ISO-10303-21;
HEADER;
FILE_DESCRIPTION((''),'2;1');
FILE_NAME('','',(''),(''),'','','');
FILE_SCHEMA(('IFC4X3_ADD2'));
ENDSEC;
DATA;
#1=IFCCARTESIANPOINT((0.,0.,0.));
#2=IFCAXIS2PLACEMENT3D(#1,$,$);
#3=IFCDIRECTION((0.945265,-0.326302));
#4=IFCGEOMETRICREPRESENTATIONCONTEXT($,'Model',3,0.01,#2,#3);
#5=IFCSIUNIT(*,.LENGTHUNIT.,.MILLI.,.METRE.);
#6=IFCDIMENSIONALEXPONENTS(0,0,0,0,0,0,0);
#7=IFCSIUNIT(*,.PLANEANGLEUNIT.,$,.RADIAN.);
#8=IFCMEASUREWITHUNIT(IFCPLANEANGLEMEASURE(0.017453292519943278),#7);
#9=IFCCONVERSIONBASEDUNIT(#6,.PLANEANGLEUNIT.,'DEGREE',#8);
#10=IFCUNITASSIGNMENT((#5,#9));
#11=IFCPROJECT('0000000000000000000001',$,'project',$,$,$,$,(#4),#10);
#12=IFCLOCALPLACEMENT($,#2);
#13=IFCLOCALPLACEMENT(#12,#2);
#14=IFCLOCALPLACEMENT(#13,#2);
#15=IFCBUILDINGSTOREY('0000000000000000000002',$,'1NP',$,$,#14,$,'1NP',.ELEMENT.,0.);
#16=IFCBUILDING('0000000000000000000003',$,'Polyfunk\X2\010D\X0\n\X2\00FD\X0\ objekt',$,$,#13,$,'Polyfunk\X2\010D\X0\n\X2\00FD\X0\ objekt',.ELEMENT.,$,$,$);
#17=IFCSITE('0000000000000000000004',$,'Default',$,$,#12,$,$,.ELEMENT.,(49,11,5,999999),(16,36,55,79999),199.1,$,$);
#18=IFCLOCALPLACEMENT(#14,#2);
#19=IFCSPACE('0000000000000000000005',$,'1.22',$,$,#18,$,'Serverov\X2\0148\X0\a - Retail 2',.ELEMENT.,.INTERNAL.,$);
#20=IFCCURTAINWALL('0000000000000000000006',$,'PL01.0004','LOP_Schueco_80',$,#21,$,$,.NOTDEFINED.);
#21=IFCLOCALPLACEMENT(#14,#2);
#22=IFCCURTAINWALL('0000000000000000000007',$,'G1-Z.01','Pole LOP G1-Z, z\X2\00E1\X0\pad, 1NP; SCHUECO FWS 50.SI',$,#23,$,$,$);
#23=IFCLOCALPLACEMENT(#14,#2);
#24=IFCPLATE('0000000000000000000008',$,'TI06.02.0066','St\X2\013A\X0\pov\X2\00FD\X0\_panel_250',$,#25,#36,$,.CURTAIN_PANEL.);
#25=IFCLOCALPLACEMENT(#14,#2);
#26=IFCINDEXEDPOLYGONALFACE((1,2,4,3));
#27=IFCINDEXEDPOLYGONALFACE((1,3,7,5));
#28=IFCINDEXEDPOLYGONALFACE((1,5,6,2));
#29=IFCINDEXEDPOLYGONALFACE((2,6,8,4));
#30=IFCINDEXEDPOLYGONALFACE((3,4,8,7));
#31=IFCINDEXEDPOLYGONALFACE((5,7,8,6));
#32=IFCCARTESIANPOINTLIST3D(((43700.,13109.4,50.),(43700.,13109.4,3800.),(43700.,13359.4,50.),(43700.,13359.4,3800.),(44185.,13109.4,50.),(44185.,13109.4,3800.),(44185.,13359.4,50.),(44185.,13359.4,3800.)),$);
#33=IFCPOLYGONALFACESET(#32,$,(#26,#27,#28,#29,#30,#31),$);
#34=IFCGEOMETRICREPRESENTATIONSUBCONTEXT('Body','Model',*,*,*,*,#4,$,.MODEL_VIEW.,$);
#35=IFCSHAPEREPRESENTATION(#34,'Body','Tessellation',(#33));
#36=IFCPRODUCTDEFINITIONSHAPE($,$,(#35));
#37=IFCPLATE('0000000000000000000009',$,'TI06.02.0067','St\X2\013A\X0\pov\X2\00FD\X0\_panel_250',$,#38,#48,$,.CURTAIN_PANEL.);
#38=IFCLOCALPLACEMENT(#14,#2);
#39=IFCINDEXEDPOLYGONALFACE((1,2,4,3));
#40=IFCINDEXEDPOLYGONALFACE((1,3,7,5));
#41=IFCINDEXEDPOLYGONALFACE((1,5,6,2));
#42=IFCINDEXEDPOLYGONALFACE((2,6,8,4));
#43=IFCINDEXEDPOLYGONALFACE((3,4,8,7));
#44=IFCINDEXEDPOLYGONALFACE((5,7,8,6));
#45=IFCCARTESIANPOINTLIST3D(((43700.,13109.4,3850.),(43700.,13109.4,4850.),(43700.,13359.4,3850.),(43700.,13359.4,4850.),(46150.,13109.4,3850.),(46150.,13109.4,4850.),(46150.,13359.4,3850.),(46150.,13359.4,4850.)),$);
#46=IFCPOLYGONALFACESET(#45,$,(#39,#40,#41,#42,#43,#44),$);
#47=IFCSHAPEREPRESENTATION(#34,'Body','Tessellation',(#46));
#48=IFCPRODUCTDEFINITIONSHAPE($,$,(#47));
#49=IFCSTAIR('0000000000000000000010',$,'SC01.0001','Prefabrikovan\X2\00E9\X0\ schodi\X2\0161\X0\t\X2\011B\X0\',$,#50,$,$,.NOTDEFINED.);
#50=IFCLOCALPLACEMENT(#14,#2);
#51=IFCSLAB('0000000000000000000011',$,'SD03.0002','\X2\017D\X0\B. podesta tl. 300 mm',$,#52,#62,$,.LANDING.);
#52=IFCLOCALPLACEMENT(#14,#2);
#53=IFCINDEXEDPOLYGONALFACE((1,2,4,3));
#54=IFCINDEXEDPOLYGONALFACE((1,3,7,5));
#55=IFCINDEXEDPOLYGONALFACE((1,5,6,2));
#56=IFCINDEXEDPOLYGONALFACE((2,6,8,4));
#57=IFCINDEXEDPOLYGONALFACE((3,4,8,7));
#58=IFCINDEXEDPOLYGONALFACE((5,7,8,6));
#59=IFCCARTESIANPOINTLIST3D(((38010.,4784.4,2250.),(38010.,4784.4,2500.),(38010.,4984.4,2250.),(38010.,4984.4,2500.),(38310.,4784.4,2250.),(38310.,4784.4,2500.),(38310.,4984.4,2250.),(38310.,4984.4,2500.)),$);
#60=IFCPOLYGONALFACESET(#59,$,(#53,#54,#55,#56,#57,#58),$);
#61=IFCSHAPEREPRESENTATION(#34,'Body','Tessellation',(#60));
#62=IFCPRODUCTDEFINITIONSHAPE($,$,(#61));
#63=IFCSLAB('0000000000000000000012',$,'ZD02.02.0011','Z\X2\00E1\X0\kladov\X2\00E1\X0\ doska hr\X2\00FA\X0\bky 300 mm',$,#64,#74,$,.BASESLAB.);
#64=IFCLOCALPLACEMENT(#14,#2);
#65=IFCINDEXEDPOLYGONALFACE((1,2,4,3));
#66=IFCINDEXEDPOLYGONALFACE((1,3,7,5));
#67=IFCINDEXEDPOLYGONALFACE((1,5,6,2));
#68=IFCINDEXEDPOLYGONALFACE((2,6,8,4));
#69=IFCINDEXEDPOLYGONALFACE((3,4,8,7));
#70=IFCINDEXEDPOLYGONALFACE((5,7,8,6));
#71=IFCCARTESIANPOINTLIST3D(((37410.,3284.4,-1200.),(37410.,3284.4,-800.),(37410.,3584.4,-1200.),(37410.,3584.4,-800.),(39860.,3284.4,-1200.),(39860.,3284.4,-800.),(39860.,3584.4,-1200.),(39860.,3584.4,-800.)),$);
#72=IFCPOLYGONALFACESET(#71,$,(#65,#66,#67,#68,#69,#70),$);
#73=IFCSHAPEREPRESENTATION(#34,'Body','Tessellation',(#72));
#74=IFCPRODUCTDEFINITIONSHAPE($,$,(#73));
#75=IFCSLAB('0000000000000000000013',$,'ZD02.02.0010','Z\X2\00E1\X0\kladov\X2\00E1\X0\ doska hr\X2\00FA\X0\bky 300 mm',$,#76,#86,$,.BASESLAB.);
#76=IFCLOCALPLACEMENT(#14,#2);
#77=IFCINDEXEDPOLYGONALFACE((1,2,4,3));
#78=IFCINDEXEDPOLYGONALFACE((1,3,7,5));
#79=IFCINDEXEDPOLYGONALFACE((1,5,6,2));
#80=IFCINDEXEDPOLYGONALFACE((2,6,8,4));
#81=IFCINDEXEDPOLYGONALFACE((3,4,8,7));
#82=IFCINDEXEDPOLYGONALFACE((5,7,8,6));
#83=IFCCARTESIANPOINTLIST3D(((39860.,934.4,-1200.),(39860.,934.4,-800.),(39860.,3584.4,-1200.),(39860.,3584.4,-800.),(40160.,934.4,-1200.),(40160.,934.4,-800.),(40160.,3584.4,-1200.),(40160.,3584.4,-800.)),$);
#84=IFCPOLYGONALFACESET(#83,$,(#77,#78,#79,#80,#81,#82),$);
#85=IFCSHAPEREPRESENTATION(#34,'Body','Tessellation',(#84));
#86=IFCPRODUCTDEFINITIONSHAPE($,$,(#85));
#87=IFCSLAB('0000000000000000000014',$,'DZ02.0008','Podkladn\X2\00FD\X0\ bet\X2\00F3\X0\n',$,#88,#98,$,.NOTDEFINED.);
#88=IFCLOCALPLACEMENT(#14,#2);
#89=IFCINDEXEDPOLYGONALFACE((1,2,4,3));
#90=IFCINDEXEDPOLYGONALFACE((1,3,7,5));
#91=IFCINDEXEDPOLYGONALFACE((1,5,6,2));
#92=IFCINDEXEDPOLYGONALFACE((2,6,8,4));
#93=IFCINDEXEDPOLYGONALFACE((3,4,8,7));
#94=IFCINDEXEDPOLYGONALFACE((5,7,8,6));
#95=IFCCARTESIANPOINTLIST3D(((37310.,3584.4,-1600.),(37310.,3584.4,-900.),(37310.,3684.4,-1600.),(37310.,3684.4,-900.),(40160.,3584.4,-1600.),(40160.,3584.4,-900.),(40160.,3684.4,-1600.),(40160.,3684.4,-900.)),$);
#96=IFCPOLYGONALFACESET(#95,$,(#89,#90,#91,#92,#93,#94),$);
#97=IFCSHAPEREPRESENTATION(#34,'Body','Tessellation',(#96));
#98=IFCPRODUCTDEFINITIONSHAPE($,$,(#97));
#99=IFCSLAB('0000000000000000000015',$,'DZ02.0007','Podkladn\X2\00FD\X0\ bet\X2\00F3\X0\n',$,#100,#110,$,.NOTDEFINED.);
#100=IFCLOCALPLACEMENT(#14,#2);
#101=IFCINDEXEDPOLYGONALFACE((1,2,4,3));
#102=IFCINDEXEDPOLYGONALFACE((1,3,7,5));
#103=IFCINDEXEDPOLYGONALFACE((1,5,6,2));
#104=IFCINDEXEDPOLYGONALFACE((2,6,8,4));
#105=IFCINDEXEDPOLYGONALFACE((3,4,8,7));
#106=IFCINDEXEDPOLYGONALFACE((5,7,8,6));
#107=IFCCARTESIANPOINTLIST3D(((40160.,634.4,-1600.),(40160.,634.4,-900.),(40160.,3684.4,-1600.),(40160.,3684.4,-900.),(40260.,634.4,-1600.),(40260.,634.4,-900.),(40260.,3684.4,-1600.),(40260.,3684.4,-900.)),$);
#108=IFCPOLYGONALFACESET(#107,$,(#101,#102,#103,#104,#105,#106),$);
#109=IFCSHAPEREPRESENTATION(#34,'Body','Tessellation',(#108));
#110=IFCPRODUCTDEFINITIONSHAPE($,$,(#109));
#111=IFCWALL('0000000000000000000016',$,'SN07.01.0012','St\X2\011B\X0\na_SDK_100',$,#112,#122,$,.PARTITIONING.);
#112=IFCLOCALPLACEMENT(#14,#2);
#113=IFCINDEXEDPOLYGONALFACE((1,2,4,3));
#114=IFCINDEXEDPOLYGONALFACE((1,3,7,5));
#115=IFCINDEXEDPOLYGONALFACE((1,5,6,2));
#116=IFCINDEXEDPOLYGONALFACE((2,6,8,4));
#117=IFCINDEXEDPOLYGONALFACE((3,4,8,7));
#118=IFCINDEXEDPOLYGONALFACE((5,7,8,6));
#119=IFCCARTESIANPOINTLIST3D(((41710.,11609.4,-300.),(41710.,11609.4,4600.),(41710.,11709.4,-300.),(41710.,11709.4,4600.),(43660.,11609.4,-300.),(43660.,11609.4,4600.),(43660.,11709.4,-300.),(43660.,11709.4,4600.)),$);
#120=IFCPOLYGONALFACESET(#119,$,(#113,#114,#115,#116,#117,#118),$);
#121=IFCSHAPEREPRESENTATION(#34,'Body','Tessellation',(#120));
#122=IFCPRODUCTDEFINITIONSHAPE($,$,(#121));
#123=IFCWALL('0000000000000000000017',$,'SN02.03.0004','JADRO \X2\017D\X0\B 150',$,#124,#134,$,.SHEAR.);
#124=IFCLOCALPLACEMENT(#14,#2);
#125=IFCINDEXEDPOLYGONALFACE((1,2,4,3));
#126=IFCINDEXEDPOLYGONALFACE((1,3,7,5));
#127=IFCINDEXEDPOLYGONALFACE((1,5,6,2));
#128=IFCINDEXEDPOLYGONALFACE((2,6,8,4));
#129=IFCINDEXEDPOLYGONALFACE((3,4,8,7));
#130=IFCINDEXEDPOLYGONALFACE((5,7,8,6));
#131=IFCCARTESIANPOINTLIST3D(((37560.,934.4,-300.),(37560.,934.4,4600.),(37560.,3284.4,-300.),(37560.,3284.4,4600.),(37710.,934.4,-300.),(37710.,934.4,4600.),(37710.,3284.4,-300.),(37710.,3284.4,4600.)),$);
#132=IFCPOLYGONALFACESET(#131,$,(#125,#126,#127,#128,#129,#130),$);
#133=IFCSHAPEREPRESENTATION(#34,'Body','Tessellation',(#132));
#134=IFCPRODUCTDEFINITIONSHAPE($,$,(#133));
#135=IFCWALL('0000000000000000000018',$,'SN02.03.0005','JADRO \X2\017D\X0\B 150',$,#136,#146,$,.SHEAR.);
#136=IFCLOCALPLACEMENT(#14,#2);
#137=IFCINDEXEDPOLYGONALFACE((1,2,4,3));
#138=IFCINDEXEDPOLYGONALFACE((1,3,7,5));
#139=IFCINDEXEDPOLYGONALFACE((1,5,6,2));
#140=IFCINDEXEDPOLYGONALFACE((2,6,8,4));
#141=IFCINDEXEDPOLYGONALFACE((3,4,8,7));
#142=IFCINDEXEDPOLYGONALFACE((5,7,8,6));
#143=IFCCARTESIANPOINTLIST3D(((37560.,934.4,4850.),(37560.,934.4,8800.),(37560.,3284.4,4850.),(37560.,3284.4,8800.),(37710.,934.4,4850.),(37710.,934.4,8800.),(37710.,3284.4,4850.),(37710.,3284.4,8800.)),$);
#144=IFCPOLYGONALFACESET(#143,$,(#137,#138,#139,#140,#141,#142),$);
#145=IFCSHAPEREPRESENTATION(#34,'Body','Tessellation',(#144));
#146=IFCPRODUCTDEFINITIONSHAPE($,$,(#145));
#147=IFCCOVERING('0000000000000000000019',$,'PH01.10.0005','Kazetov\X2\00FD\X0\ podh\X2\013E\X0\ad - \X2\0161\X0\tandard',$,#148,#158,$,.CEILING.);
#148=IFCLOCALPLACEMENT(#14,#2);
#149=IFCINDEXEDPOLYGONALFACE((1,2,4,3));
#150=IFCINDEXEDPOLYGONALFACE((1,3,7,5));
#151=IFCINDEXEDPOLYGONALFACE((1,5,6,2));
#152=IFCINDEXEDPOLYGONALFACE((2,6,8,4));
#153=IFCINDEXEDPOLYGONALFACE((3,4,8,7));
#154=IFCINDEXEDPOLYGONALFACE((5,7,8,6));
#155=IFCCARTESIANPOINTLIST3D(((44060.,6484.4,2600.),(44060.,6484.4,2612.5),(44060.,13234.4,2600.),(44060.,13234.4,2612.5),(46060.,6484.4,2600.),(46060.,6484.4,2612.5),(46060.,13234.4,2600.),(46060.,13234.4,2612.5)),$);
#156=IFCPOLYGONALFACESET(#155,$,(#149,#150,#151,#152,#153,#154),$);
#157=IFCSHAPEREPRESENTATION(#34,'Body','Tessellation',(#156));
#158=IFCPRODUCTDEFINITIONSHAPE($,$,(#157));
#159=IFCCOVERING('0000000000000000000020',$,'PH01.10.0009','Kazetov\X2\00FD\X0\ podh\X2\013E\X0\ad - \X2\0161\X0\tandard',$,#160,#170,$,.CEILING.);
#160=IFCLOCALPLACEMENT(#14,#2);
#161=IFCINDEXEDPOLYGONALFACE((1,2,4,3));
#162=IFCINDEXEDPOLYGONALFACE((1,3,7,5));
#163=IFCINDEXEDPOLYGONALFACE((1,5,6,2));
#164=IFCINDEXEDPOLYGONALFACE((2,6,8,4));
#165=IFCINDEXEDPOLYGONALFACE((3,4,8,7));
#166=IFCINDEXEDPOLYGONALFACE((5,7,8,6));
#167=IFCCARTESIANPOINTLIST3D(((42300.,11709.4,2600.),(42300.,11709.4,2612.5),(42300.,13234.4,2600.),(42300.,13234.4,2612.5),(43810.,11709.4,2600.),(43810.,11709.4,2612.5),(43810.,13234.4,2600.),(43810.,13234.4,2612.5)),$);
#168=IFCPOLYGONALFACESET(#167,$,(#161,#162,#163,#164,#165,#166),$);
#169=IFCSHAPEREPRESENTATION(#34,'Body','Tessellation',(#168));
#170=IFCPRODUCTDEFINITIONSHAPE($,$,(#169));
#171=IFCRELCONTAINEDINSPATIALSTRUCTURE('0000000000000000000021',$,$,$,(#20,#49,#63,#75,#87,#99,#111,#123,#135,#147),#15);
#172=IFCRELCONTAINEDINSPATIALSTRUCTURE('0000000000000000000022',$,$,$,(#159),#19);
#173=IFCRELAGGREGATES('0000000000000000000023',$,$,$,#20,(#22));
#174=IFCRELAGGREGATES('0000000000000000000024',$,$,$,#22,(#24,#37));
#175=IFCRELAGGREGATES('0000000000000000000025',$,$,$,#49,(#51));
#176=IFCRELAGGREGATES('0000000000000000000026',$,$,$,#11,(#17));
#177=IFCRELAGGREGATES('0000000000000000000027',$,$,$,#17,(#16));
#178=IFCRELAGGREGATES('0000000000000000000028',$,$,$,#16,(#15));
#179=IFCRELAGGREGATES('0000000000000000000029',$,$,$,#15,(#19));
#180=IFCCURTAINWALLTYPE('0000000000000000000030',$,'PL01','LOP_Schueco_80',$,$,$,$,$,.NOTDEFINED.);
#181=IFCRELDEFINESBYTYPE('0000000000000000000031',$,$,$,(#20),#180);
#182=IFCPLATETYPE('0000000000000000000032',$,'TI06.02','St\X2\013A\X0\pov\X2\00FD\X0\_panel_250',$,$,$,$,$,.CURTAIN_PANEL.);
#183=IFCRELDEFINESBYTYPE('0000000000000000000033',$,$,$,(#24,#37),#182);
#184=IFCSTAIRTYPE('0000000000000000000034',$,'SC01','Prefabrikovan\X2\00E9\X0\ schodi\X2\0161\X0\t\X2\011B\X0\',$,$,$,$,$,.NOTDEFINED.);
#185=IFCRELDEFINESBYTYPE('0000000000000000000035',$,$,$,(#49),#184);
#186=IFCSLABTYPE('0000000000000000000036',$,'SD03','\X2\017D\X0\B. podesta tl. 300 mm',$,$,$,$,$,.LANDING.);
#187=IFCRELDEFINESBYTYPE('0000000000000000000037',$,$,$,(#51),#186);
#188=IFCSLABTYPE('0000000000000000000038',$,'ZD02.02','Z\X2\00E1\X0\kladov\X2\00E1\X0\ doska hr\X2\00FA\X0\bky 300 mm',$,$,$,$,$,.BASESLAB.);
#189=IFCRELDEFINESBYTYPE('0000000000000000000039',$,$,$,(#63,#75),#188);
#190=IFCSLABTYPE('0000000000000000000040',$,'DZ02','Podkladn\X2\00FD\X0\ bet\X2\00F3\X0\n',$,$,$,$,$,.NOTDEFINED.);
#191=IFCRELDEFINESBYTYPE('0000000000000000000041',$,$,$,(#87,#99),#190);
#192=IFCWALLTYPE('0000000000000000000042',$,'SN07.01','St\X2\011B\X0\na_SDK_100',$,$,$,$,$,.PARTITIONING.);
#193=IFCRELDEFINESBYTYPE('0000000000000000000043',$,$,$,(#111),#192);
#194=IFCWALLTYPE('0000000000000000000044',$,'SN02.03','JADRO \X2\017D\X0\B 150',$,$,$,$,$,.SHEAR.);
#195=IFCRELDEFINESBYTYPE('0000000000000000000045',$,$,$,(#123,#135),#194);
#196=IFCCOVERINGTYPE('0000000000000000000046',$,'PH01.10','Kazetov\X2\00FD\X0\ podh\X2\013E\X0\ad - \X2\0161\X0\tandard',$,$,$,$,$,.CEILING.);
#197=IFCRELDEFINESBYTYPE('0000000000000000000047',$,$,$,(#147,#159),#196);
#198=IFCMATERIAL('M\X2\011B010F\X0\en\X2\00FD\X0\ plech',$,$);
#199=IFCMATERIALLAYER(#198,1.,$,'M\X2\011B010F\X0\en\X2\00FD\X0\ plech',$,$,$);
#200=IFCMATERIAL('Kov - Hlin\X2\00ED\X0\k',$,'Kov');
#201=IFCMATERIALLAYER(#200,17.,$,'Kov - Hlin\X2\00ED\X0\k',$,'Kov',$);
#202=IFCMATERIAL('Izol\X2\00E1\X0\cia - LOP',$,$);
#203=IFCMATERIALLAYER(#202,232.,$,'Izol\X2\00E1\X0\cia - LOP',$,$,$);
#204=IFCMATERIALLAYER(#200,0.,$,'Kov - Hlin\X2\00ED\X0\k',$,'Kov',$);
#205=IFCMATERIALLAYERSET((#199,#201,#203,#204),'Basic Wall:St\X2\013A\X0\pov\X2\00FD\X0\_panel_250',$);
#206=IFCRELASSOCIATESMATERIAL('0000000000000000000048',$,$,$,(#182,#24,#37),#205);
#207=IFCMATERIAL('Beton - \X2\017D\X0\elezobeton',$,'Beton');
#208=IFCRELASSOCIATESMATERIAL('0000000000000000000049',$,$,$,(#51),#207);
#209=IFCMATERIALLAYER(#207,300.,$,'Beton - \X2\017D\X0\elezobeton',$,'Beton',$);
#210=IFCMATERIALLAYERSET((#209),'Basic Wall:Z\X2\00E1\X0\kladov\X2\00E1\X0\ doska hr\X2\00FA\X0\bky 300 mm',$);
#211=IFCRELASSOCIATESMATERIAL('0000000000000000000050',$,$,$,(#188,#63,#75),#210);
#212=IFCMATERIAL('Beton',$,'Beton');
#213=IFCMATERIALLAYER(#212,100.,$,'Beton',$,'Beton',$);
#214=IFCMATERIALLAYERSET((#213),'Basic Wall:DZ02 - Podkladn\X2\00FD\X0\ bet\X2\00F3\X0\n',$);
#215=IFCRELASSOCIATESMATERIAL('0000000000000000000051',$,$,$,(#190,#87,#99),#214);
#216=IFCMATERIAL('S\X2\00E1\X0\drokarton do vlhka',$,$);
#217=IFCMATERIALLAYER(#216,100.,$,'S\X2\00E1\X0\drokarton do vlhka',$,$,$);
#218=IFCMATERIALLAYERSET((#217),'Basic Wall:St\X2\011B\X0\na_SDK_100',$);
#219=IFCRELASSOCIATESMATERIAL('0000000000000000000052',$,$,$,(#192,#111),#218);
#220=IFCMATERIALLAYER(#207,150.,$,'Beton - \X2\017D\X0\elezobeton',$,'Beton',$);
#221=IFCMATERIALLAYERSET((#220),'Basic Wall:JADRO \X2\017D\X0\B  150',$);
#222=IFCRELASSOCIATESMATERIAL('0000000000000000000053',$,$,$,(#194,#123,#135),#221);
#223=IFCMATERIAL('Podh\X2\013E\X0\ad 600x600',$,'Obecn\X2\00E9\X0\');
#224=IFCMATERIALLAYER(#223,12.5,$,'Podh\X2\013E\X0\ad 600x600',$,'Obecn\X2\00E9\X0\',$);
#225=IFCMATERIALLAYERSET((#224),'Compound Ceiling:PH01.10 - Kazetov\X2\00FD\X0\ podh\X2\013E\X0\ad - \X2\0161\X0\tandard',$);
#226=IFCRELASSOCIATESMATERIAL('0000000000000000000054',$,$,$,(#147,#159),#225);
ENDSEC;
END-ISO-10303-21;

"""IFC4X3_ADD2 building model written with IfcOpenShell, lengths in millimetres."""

from ifc_helpers import new_model, entity, si_unit, converted_unit, direction, frame, frame_2d, origin, place, context, subcontext, project, spatial, polyline, rectangle, extrude, clip, bounded_halfspace, material, layer, layer_set, layer_usage, type_object, element, aggregate, save


model = new_model("IFC4X3_ADD2")

# Units and contexts
model_context = context("Model", 3, precision=0.01, world=origin(), true_north=direction((0.945265, -0.326302)))
body_context = subcontext(model_context, "Body", "Model", "MODEL_VIEW")
ifc_project = project(units=[si_unit("LENGTHUNIT", "METRE", prefix="MILLI"), converted_unit("PLANEANGLEUNIT", "DEGREE", entity("IfcPlaneAngleMeasure", 0.017453292519943278), si_unit("PLANEANGLEUNIT", "RADIAN"), dimensions=[0, 0, 0, 0, 0, 0, 0])], contexts=[model_context])

# Site, building, storey
site_placement = place(None, origin())
site = spatial("IfcSite", under=ifc_project, at=site_placement, Name="Default", CompositionType="ELEMENT", RefLatitude=(49, 11, 5, 999999), RefLongitude=(16, 36, 55, 79999), RefElevation=199.1)
building_placement = place(site_placement, origin())
building = spatial("IfcBuilding", under=site, at=building_placement, Name="Polyfunkčný objekt", LongName="Polyfunkčný objekt", CompositionType="ELEMENT")
storey_placement = place(building_placement, origin())
storey = spatial("IfcBuildingStorey", under=building, at=storey_placement, Name="1NP", LongName="1NP", CompositionType="ELEMENT", Elevation=0.0)

# Curtain walls, plates
curtain_wall_type = type_object("IfcCurtainWallType", Name="PL01", Description="LOP_Schueco_80", PredefinedType="NOTDEFINED")
curtain_wall_1_placement = place(storey_placement, origin())
curtain_wall_1 = element("IfcCurtainWall", 1, at=curtain_wall_1_placement, inside=storey, type_object=curtain_wall_type, Name="PL01.0004", Description="LOP_Schueco_80", PredefinedType="NOTDEFINED")
curtain_wall_2 = element("IfcCurtainWall", 2, Name="G1-Z.01", Description="Pole LOP G1-Z, západ, 1NP; SCHUECO FWS 50.SI")
aggregate(curtain_wall_1, [curtain_wall_2])
ifc_material_1 = material(Name="Měďený plech")
ifc_layer_1 = layer(ifc_material_1, 1.0, Name="Měďený plech")
ifc_material_2 = material(Name="Kov - Hliník", Category="Kov")
ifc_layer_2 = layer(ifc_material_2, 17.0, Name="Kov - Hliník", Category="Kov")
ifc_material_3 = material(Name="Izolácia - LOP")
ifc_layer_3 = layer(ifc_material_3, 232.0, Name="Izolácia - LOP")
ifc_layer_4 = layer(ifc_material_2, 0.0, Name="Kov - Hliník", Category="Kov")
ifc_layer_set_1 = layer_set([ifc_layer_1, ifc_layer_2, ifc_layer_3, ifc_layer_4], Name="Basic Wall:Stĺpový_panel_250")
ifc_layer_usage_1 = layer_usage(ifc_layer_set_1, "AXIS2", "NEGATIVE", 125.0)
plate_type = type_object("IfcPlateType", Name="TI06.02", Description="Stĺpový_panel_250", PredefinedType="CURTAIN_PANEL", material=ifc_layer_set_1)
plate_1_placement = place(storey_placement, frame((43700.0, 13234.4, 50.0)))
plate_1 = element("IfcPlate", 3, at=plate_1_placement, type_object=plate_type, material=ifc_layer_usage_1, Name="TI06.02.0066", Description="Stĺpový_panel_250", PredefinedType="CURTAIN_PANEL", context=body_context, shape_type="SweptSolid", body=[
    extrude(rectangle(XDim=250.0, YDim=485.0, at=frame_2d((0.0, 0.0), x_axis=(1.0, 0.0))), frame((242.5, 0.0, 0.0), z_axis=(0.0, 0.0, 1.0), x_axis=(0.0, 1.0, 0.0)), (0.0, 0.0, 1.0), 3750.0),
])
ifc_layer_usage_2 = layer_usage(ifc_layer_set_1, "AXIS2", "NEGATIVE", 125.0)
plate_2_placement = place(storey_placement, frame((43700.0, 13234.4, 3850.0)))
plate_2 = element("IfcPlate", 4, at=plate_2_placement, type_object=plate_type, material=ifc_layer_usage_2, Name="TI06.02.0067", Description="Stĺpový_panel_250", PredefinedType="CURTAIN_PANEL", context=body_context, shape_type="SweptSolid", body=[
    extrude(rectangle(XDim=250.0, YDim=2450.0, at=frame_2d((0.0, 0.0), x_axis=(1.0, 0.0))), frame((1225.0, 0.0, 0.0), z_axis=(0.0, 0.0, 1.0), x_axis=(0.0, 1.0, 0.0)), (0.0, 0.0, 1.0), 1000.0),
])
aggregate(curtain_wall_2, [plate_1, plate_2])

# Stair, slab
stair_type = type_object("IfcStairType", Name="SC01", Description="Prefabrikované schodiště", PredefinedType="NOTDEFINED")
stair_placement = place(storey_placement, origin())
stair = element("IfcStair", 5, at=stair_placement, inside=storey, type_object=stair_type, Name="SC01.0001", Description="Prefabrikované schodiště", PredefinedType="NOTDEFINED")
ifc_material_4 = material(Name="Beton - Železobeton", Category="Beton")
slab_type_1 = type_object("IfcSlabType", Name="SD03", Description="ŽB. podesta tl. 300 mm", PredefinedType="LANDING")
slab_1_placement = place(stair_placement, frame((38010.0, 4784.4, 0.0)))
slab_1 = element("IfcSlab", 6, at=slab_1_placement, type_object=slab_type_1, material=ifc_material_4, Name="SD03.0002", Description="ŽB. podesta tl. 300 mm", PredefinedType="LANDING", context=body_context, shape_type="SweptSolid", body=[
    extrude(rectangle(XDim=200.0, YDim=300.0, at=frame_2d((0.0, 0.0), x_axis=(1.0, 0.0))), frame((150.0, 100.0, 2250.0), z_axis=(0.0, 0.0, 1.0), x_axis=(0.0, 1.0, 0.0)), (0.0, 0.0, 1.0), 250.0),
])
aggregate(stair, [slab_1])

# Slabs
ifc_layer_5 = layer(ifc_material_4, 300.0, Name="Beton - Železobeton", Category="Beton")
ifc_layer_set_2 = layer_set([ifc_layer_5], Name="Basic Wall:Základová doska hrúbky 300 mm")
slab_type_2 = type_object("IfcSlabType", Name="ZD02.02", Description="Základová doska hrúbky 300 mm", PredefinedType="BASESLAB", material=ifc_layer_set_2)
slab_2_placement = place(storey_placement, frame((37410.0, 3434.4, -1200.0)))
element("IfcSlab", 7, at=slab_2_placement, inside=storey, type_object=slab_type_2, material=ifc_layer_set_2, Name="ZD02.02.0011", Description="Základová doska hrúbky 300 mm", PredefinedType="BASESLAB", context=body_context, shape_type="SweptSolid", body=[
    extrude(rectangle(XDim=2450.0, YDim=300.0, at=frame_2d((1225.0, 0.0), x_axis=(-1.0, 0.0))), origin(), (0.0, 0.0, 1.0), 400.0),
])
slab_3_placement = place(storey_placement, frame((40010.0, 3584.4, -1200.0), z_axis=(0.0, 0.0, 1.0), x_axis=(0.0, -1.0, 0.0)))
element("IfcSlab", 8, at=slab_3_placement, inside=storey, type_object=slab_type_2, material=ifc_layer_set_2, Name="ZD02.02.0010", Description="Základová doska hrúbky 300 mm", PredefinedType="BASESLAB", context=body_context, shape_type="SweptSolid", body=[
    extrude(rectangle(XDim=2650.0, YDim=300.0, at=frame_2d((1325.0, 0.0), x_axis=(-1.0, 0.0))), origin(), (0.0, 0.0, 1.0), 400.0),
])
ifc_material_5 = material(Name="Beton", Category="Beton")
ifc_layer_6 = layer(ifc_material_5, 100.0, Name="Beton", Category="Beton")
ifc_layer_set_3 = layer_set([ifc_layer_6], Name="Basic Wall:DZ02 - Podkladný betón")
slab_type_3 = type_object("IfcSlabType", Name="DZ02", Description="Podkladný betón", PredefinedType="NOTDEFINED", material=ifc_layer_set_3)
slab_4_placement = place(storey_placement, frame((37310.0, 3634.4, -1600.0)))
element("IfcSlab", 9, at=slab_4_placement, inside=storey, type_object=slab_type_3, material=ifc_layer_set_3, Name="DZ02.0008", Description="Podkladný betón", PredefinedType="NOTDEFINED", context=body_context, shape_type="SweptSolid", body=[
    extrude(rectangle(XDim=2850.0, YDim=100.0, at=frame_2d((1425.0, 0.0), x_axis=(-1.0, 0.0))), origin(), (0.0, 0.0, 1.0), 700.0),
])
slab_5_placement = place(storey_placement, frame((40210.0, 3684.4, -1600.0), z_axis=(0.0, 0.0, 1.0), x_axis=(0.0, -1.0, 0.0)))
element("IfcSlab", 10, at=slab_5_placement, inside=storey, type_object=slab_type_3, material=ifc_layer_set_3, Name="DZ02.0007", Description="Podkladný betón", PredefinedType="NOTDEFINED", context=body_context, shape_type="SweptSolid", body=[
    extrude(rectangle(XDim=3050.0, YDim=100.0, at=frame_2d((1525.0, 0.0), x_axis=(-1.0, 0.0))), origin(), (0.0, 0.0, 1.0), 700.0),
])

# Walls
ifc_material_6 = material(Name="Sádrokarton do vlhka")
ifc_layer_7 = layer(ifc_material_6, 100.0, Name="Sádrokarton do vlhka")
ifc_layer_set_4 = layer_set([ifc_layer_7], Name="Basic Wall:Stěna_SDK_100")
wall_type_1 = type_object("IfcWallType", Name="SN07.01", Description="Stěna_SDK_100", PredefinedType="PARTITIONING", material=ifc_layer_set_4)
wall_1_placement = place(storey_placement, frame((41710.0, 11659.4, -300.0)))
element("IfcWall", 11, at=wall_1_placement, inside=storey, type_object=wall_type_1, material=ifc_layer_set_4, Name="SN07.01.0012", Description="Stěna_SDK_100", PredefinedType="PARTITIONING", context=body_context, shape_type="Clipping", body=[
    clip(clip(extrude(rectangle(XDim=1950.0, YDim=100.0, at=frame_2d((975.0, 0.0), x_axis=(-1.0, 0.0))), origin(), (0.0, 0.0, 1.0), 4900.0), bounded_halfspace(frame((0.0, -50.0, 4900.0), z_axis=(0.0, 0.0, -1.0), x_axis=(1.0, 0.0, 0.0)), True, frame((0.0, -50.0, 4900.0)), polyline([(0.0, 0.0), (900.0, 0.0), (1050.0, 0.0), (1950.0, 0.0), (1950.0, 100.0), (0.0, 100.0), (0.0, 0.0)]))), bounded_halfspace(frame((1950.0, -50.0, 0.0), z_axis=(0.0, 0.0, 1.0), x_axis=(0.0, 1.0, 0.0)), True, frame((1950.0, -50.0, 0.0)), polyline([(0.0, 0.0), (0.0, 100.0), (-1950.0, 100.0), (-1950.0, 0.0), (-1050.0, 0.0), (-900.0, 0.0), (0.0, 0.0)]))),
])
ifc_layer_8 = layer(ifc_material_4, 150.0, Name="Beton - Železobeton", Category="Beton")
ifc_layer_set_5 = layer_set([ifc_layer_8], Name="Basic Wall:JADRO ŽB  150")
wall_type_2 = type_object("IfcWallType", Name="SN02.03", Description="JADRO ŽB 150", PredefinedType="SHEAR", material=ifc_layer_set_5)
wall_2_placement = place(storey_placement, frame((37635.0, 3284.4, -300.0), z_axis=(0.0, 0.0, 1.0), x_axis=(0.0, -1.0, 0.0)))
element("IfcWall", 12, at=wall_2_placement, inside=storey, type_object=wall_type_2, material=ifc_layer_set_5, Name="SN02.03.0004", Description="JADRO ŽB 150", PredefinedType="SHEAR", context=body_context, shape_type="SweptSolid", body=[
    extrude(rectangle(XDim=2350.0, YDim=150.0, at=frame_2d((1175.0, 0.0), x_axis=(-1.0, 0.0))), origin(), (0.0, 0.0, 1.0), 4900.0),
])
wall_3_placement = place(storey_placement, frame((37635.0, 3284.4, 4850.0), z_axis=(0.0, 0.0, 1.0), x_axis=(0.0, -1.0, 0.0)))
element("IfcWall", 13, at=wall_3_placement, inside=storey, type_object=wall_type_2, material=ifc_layer_set_5, Name="SN02.03.0005", Description="JADRO ŽB 150", PredefinedType="SHEAR", context=body_context, shape_type="SweptSolid", body=[
    extrude(rectangle(XDim=2350.0, YDim=150.0, at=frame_2d((1175.0, 0.0), x_axis=(-1.0, 0.0))), origin(), (0.0, 0.0, 1.0), 3950.0),
])

# Covering
ifc_material_7 = material(Name="Podhľad 600x600", Category="Obecné")
ifc_layer_9 = layer(ifc_material_7, 12.5, Name="Podhľad 600x600", Category="Obecné")
ifc_layer_set_6 = layer_set([ifc_layer_9], Name="Compound Ceiling:PH01.10 - Kazetový podhľad - štandard")
ifc_layer_usage_3 = layer_usage(ifc_layer_set_6, "AXIS3", "NEGATIVE", 0.0)
covering_type_1 = type_object("IfcCoveringType", Name="PH01.10", Description="Kazetový podhľad - štandard", PredefinedType="CEILING")
covering_1_placement = place(storey_placement, frame((44060.0, 6484.4, 2600.0)))
element("IfcCovering", 14, at=covering_1_placement, inside=storey, type_object=covering_type_1, material=ifc_layer_usage_3, Name="PH01.10.0005", Description="Kazetový podhľad - štandard", PredefinedType="CEILING", context=body_context, shape_type="SweptSolid", body=[
    extrude(rectangle(XDim=2000.0, YDim=6750.0, at=frame_2d((0.0, 0.0), x_axis=(1.0, 0.0))), frame((1000.0, 3375.0, 0.0), z_axis=(0.0, 0.0, 1.0), x_axis=(-1.0, 0.0, 0.0)), (0.0, 0.0, 1.0), 12.5),
])

# Shared definitions
space_1_placement = place(storey_placement, origin())
space_1 = spatial("IfcSpace", under=storey, at=space_1_placement, Name="1.22", LongName="Serverovňa - Retail 2", CompositionType="ELEMENT", PredefinedType="INTERNAL")

# Covering
ifc_layer_usage_4 = layer_usage(ifc_layer_set_6, "AXIS3", "NEGATIVE", 0.0)
covering_2_placement = place(storey_placement, frame((42300.0, 11709.4, 2600.0)))
element("IfcCovering", 15, at=covering_2_placement, inside=space_1, type_object=covering_type_1, material=ifc_layer_usage_4, Name="PH01.10.0009", Description="Kazetový podhľad - štandard", PredefinedType="CEILING", context=body_context, shape_type="SweptSolid", body=[
    extrude(rectangle(XDim=1510.0, YDim=1525.0, at=frame_2d((0.0, 0.0), x_axis=(1.0, 0.0))), frame((755.0, 762.5, 0.0), z_axis=(0.0, 0.0, 1.0), x_axis=(-1.0, 0.0, 0.0)), (0.0, 0.0, 1.0), 12.5),
])

save(model, "model.ifc")
